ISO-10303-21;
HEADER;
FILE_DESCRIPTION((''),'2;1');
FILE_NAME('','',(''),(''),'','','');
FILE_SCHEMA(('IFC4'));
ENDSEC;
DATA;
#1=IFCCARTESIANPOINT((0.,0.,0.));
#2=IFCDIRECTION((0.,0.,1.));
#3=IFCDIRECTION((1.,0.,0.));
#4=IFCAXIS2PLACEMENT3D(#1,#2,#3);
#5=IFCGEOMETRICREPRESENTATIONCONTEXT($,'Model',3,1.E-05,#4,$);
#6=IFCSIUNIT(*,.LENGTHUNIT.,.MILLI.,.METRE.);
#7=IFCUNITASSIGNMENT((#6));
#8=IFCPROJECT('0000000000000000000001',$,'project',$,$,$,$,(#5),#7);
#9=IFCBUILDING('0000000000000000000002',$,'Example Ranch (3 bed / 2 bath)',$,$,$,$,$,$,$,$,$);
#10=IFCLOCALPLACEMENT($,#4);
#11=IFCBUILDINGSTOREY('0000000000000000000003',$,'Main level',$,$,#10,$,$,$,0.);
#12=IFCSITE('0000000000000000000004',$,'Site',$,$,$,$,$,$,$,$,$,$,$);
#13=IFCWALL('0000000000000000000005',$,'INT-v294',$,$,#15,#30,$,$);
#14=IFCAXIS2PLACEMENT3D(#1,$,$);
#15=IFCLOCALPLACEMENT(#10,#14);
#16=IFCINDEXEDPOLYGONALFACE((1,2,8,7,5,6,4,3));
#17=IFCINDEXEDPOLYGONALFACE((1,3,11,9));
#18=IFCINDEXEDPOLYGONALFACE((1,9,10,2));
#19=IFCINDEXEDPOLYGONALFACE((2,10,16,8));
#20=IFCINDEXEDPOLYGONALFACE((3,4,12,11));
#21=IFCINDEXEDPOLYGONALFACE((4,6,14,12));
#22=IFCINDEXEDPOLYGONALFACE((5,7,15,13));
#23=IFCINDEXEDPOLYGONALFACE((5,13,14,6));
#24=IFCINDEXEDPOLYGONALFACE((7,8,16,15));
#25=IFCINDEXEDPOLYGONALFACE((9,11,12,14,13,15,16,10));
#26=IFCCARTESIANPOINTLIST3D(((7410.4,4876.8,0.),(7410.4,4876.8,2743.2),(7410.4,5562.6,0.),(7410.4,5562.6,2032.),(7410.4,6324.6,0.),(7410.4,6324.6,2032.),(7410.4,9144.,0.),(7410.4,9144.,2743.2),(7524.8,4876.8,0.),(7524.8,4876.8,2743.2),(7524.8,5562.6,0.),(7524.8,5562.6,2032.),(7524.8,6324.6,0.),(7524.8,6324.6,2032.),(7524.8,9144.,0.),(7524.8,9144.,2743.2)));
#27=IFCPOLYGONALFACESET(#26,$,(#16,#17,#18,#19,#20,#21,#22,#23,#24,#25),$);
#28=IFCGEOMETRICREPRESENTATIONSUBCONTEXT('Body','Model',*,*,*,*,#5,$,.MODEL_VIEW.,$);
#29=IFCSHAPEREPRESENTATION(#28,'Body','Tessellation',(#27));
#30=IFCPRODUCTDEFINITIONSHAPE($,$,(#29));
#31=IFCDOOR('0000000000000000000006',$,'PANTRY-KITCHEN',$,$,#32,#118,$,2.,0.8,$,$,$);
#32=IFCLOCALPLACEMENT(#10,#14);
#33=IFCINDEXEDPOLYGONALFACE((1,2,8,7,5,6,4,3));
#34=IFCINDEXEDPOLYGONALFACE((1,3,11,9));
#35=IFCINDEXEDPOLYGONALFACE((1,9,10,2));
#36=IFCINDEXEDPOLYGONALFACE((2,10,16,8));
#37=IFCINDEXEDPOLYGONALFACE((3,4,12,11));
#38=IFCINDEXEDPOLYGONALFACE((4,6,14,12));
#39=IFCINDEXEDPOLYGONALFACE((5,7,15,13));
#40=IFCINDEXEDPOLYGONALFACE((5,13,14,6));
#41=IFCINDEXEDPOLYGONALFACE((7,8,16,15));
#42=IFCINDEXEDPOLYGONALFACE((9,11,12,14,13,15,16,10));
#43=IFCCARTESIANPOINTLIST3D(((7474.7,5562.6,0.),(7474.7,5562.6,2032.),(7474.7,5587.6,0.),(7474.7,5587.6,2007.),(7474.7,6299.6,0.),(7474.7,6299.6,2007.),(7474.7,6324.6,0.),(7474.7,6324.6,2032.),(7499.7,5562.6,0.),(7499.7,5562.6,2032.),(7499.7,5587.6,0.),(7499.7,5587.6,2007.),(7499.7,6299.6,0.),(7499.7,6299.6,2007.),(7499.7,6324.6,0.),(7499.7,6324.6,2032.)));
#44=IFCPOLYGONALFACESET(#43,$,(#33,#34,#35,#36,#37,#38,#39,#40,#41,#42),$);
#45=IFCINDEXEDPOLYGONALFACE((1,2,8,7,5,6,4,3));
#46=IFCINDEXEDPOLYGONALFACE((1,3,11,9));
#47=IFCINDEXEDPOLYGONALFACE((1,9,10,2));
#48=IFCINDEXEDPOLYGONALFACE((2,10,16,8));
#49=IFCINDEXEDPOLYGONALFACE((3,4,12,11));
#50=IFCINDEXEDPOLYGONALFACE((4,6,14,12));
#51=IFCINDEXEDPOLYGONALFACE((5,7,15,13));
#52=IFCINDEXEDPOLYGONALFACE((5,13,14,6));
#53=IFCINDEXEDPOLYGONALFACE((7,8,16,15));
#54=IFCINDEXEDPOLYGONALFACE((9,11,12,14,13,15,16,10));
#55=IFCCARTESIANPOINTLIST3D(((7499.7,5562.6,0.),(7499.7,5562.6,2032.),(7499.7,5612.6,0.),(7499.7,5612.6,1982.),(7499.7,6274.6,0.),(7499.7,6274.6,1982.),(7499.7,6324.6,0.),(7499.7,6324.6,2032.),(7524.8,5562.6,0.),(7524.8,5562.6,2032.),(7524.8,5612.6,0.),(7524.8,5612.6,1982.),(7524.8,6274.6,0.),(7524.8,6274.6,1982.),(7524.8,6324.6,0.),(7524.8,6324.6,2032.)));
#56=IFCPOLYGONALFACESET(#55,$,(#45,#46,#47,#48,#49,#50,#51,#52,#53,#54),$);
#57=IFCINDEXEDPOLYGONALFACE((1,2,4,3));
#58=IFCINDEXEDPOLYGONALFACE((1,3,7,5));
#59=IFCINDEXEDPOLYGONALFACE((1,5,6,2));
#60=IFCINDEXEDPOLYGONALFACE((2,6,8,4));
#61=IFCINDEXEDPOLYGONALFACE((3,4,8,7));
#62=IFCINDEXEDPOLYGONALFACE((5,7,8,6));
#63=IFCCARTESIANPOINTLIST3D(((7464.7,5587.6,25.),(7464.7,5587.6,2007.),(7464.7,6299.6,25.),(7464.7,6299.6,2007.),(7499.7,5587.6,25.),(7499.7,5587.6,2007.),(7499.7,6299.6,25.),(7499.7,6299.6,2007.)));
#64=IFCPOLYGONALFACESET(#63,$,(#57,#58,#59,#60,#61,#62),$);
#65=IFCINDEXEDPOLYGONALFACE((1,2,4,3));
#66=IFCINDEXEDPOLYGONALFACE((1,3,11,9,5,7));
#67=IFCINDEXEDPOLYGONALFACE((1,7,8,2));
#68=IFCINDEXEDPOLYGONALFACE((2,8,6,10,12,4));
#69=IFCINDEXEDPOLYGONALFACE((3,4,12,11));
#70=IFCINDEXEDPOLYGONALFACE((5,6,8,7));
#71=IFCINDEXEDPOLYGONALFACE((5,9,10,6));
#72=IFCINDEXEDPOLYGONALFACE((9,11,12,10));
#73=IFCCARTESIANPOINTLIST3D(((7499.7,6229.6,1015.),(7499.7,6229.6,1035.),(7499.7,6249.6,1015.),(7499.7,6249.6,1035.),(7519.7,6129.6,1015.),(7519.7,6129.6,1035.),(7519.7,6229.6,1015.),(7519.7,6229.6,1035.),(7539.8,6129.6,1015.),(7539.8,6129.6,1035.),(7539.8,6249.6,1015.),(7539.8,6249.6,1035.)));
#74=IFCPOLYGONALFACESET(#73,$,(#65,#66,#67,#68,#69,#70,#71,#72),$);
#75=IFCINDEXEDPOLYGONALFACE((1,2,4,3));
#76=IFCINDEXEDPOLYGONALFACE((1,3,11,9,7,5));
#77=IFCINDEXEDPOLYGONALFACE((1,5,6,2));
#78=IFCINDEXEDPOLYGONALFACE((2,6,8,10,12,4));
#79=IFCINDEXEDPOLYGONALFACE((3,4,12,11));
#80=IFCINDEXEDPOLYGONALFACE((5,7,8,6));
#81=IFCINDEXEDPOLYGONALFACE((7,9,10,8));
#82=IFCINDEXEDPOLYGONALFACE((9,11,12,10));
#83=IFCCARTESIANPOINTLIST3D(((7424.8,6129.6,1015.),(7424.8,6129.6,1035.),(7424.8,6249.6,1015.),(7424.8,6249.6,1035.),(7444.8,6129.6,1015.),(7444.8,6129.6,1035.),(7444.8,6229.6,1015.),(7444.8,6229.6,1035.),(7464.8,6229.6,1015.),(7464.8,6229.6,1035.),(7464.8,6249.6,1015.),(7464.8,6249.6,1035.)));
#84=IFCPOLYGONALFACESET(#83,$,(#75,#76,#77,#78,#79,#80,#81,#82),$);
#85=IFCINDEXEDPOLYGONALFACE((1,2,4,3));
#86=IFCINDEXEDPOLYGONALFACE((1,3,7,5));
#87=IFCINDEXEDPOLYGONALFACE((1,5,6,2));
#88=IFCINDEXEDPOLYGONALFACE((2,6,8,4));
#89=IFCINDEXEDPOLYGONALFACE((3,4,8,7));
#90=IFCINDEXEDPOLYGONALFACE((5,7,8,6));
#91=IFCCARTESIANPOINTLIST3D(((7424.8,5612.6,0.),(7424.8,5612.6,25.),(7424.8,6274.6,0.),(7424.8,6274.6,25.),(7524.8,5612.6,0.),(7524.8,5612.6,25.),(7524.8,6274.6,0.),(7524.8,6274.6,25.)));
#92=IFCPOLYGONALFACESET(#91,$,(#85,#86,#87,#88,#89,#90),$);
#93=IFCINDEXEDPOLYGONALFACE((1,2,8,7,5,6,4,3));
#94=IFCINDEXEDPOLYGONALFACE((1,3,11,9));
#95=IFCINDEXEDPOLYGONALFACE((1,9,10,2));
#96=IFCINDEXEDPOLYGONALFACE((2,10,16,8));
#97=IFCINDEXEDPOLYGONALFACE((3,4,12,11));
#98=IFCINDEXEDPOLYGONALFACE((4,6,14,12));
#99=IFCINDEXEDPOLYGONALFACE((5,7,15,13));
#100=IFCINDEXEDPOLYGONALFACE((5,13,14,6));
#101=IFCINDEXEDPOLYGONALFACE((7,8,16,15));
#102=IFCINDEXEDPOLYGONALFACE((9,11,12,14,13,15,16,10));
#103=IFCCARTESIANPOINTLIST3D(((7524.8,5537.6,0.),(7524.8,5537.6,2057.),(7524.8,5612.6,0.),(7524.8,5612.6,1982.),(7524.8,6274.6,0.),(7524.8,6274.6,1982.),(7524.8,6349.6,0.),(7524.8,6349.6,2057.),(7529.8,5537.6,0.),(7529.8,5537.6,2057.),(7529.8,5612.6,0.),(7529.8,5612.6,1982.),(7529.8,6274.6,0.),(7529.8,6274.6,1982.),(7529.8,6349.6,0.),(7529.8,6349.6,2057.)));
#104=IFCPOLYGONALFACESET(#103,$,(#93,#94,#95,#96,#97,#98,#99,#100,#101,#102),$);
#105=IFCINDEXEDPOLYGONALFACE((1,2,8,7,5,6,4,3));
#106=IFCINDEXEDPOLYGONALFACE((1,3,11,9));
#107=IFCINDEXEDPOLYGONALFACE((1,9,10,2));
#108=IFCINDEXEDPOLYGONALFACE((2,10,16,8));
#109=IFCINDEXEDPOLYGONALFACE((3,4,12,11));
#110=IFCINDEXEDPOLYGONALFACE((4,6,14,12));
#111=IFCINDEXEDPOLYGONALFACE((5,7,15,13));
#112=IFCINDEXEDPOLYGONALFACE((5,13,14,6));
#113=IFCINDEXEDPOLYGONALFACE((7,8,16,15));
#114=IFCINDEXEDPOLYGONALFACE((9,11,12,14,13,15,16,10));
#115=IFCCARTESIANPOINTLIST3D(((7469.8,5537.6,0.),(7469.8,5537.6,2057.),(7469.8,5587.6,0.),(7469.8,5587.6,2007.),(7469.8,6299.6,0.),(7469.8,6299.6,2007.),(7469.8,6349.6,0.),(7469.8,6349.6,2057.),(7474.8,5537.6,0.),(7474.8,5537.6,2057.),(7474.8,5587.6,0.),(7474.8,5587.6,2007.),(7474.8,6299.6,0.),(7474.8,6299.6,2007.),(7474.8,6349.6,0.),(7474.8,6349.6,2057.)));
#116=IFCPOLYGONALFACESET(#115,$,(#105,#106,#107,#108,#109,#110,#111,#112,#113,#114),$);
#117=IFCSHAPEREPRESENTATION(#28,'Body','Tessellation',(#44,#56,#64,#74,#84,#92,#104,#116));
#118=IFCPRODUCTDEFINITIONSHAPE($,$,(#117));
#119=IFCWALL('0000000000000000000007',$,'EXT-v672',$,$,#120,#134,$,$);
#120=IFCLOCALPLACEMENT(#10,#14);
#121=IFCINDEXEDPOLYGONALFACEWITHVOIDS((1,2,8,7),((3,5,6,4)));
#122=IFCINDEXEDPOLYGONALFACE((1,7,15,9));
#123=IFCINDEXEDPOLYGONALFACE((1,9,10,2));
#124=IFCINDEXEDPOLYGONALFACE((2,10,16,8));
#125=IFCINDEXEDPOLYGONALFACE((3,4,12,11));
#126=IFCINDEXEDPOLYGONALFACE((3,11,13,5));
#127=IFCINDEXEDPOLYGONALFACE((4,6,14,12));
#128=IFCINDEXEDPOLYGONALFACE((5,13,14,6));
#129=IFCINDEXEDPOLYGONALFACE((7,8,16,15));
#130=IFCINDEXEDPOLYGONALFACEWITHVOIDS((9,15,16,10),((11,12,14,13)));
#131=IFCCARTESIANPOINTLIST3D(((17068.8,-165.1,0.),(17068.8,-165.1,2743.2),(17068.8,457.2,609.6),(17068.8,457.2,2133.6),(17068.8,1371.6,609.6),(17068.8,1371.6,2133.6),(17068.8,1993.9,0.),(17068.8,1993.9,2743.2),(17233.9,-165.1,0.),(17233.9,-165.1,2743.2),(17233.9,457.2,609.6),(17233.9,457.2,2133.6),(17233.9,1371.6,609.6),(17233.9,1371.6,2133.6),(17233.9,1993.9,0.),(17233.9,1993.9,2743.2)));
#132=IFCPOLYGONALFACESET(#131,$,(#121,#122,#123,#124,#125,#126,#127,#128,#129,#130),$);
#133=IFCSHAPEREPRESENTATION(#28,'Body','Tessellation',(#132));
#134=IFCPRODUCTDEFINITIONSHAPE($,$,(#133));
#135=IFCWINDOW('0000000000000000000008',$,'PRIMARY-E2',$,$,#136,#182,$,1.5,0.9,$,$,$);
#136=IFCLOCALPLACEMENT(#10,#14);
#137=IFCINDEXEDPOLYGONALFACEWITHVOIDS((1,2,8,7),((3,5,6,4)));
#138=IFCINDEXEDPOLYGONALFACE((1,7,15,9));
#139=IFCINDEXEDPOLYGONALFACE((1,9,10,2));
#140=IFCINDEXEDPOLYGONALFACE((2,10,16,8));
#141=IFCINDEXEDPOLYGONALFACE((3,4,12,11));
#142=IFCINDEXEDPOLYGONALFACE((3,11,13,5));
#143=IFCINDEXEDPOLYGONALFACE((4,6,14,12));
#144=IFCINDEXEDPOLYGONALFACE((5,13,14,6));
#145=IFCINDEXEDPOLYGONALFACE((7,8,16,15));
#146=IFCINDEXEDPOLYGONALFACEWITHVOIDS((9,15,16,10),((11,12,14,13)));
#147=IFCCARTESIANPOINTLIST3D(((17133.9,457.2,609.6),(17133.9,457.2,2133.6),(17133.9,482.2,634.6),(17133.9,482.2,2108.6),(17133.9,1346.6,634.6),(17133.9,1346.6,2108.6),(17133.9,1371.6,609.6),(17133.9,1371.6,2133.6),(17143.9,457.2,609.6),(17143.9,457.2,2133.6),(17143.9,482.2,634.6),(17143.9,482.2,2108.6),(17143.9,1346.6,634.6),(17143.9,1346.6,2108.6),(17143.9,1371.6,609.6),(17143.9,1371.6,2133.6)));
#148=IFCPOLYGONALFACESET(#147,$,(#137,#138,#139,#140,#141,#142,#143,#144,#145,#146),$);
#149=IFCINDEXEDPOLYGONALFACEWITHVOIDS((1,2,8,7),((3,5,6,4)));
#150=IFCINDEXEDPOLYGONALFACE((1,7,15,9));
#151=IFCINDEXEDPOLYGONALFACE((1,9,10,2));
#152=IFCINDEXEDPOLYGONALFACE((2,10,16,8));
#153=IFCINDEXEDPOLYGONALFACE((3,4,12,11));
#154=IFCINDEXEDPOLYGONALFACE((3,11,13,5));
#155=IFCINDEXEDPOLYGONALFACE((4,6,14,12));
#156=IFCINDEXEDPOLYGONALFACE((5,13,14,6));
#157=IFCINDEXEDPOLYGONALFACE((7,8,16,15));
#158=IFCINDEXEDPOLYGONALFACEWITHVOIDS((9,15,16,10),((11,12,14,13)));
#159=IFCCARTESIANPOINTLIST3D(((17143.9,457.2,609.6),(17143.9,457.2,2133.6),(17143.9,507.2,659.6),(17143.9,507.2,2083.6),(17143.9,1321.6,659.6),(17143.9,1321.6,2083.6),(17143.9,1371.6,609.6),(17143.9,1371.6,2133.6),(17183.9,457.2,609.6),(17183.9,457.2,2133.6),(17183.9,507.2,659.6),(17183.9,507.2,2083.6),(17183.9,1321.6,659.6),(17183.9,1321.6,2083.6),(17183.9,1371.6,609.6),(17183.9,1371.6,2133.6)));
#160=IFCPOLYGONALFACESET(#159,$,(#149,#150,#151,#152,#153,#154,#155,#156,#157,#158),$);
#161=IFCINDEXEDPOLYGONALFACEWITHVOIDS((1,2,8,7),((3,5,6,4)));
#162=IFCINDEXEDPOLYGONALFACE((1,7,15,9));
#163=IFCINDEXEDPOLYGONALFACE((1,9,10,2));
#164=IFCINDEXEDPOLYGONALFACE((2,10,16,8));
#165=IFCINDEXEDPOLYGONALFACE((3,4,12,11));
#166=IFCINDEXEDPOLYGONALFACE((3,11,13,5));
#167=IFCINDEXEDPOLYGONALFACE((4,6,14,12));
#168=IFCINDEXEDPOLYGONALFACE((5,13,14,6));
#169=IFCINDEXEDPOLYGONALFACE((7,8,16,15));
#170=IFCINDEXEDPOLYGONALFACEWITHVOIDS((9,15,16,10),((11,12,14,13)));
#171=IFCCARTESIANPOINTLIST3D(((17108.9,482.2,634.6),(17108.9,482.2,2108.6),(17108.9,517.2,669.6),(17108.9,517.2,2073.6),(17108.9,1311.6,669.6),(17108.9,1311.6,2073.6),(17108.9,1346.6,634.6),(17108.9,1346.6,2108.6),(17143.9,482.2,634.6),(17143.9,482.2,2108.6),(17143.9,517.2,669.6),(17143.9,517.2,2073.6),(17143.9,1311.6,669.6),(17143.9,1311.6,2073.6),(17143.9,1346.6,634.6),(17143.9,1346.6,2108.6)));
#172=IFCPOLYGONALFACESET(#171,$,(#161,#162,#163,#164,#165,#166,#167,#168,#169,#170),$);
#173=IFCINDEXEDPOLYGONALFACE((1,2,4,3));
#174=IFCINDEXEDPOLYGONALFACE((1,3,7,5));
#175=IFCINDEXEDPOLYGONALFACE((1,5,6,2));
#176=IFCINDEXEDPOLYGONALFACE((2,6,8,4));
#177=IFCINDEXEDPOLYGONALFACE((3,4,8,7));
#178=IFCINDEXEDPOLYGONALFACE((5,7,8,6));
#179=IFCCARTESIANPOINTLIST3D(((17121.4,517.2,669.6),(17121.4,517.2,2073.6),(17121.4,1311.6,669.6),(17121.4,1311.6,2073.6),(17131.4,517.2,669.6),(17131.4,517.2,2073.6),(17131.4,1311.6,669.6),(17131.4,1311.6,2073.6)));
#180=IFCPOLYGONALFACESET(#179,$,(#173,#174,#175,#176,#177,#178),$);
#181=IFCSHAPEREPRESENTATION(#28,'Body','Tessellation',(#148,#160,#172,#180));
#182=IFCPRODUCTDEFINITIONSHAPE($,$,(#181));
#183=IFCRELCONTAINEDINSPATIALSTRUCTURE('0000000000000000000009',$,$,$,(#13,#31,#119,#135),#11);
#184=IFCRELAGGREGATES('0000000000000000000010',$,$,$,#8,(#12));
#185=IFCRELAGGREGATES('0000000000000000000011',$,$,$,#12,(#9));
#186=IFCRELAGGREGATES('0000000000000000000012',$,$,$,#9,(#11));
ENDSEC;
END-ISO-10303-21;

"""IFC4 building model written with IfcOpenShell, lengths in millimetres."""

from ifc_helpers import new_model, si_unit, frame, origin_with_axes, place, context, subcontext, project, spatial, line, indexed_curve, outline, extrude, element, fill, save


model = new_model("IFC4")

# Units and contexts
model_context = context("Model", 3, precision=1e-05, world=origin_with_axes())
body_context = subcontext(model_context, "Body", "Model", "MODEL_VIEW")
ifc_project = project(units=[si_unit("LENGTHUNIT", "METRE", prefix="MILLI")], contexts=[model_context])

# Site, building, storey
site = spatial("IfcSite", under=ifc_project, Name="Site")
building = spatial("IfcBuilding", under=site, Name="Example Ranch (3 bed / 2 bath)")
storey_placement = place(None, origin_with_axes())
storey = spatial("IfcBuildingStorey", under=building, at=storey_placement, Name="Main level", Elevation=0.0)

# Wall, opening, door
wall_1_placement = place(storey_placement, frame((7524.8, 4876.8, 0.0), z_axis=(0.0, 0.0, 1.0), x_axis=(0.0, 1.0, 0.0)))
wall_1 = element("IfcWall", 1, at=wall_1_placement, inside=storey, Name="INT-v294", context=body_context, shape_type="SweptSolid", body=[
    extrude(outline(indexed_curve([(0.0, 0.0), (0.0, 114.3), (4267.2, 114.3), (4267.2, 0.0), (0.0, 0.0)], self_intersect=False)), origin_with_axes(), (0.0, 0.0, 1.0), 2743.2),
])
opening_1_placement = place(wall_1_placement, frame((685.8, 0.0, 0.0), z_axis=(0.0, 0.0, 1.0), x_axis=(1.0, 0.0, 0.0)))
opening_1 = element("IfcOpeningElement", 2, at=opening_1_placement, cuts=wall_1, context=body_context, shape_type="SweptSolid", body=[
    extrude(outline(indexed_curve([(0.0, 0.0), (0.0, 114.3), (762.0, 114.3), (762.0, 0.0), (0.0, 0.0)], self_intersect=False)), origin_with_axes(), (0.0, 0.0, 1.0), 2032.0),
])
door_1_placement = place(storey_placement, frame((7524.8, 5562.6, 0.0), z_axis=(0.0, 0.0, 1.0), x_axis=(0.0, 1.0, 0.0)))
door_1 = element("IfcDoor", 3, at=door_1_placement, inside=storey, Name="PANTRY-KITCHEN", OverallHeight=2.0, OverallWidth=0.8, context=body_context, shape_type="SweptSolid", body=[
    extrude(outline(indexed_curve([(0.0, 0.0), (0.0, 2032.0), (762.0, 2032.0), (762.0, 0.0), (737.0, 0.0), (737.0, 2007.0), (25.0, 2007.0), (25.0, 0.0)], segments=[line(1, 2, 3, 4, 5, 6, 7, 8, 1)])), frame((0.0, 25.0, 0.0), z_axis=(0.0, -1.0, 0.0), x_axis=(1.0, 0.0, 0.0)), (0.0, 0.0, -1.0), 25.0),
    extrude(outline(indexed_curve([(0.0, 0.0), (0.0, 2032.0), (762.0, 2032.0), (762.0, 0.0), (712.0, 0.0), (712.0, 1982.0), (50.0, 1982.0), (50.0, 0.0)], segments=[line(1, 2, 3, 4, 5, 6, 7, 8, 1)])), frame((0.0, 0.0, 0.0), z_axis=(0.0, -1.0, 0.0), x_axis=(1.0, 0.0, 0.0)), (0.0, 0.0, -1.0), 25.0),
    extrude(outline(indexed_curve([(0.0, 0.0), (712.0, 0.0), (712.0, 35.0), (0.0, 35.0)], segments=[line(1, 2, 3, 4, 1)])), frame((25.0, 25.0, 25.0), z_axis=(0.0, 0.0, 1.0), x_axis=(1.0, 0.0, 0.0)), (0.0, 0.0, 1.0), 1982.0),
    extrude(outline(indexed_curve([(0.0, 0.0), (0.0, -40.0), (-120.0, -40.0), (-120.0, -20.0), (-20.0, -20.0), (-20.0, 0.0)], segments=[line(1, 2, 3, 4, 5, 6, 1)])), frame((687.0, 25.0, 1015.0), z_axis=(0.0, 0.0, 1.0), x_axis=(1.0, 0.0, 0.0)), (0.0, 0.0, 1.0), 20.0),
    extrude(outline(indexed_curve([(0.0, 0.0), (0.0, 40.0), (-120.0, 40.0), (-120.0, 20.0), (-20.0, 20.0), (-20.0, 0.0)], segments=[line(1, 2, 3, 4, 5, 6, 1)])), frame((687.0, 60.0, 1015.0), z_axis=(0.0, 0.0, 1.0), x_axis=(1.0, 0.0, 0.0)), (0.0, 0.0, 1.0), 20.0),
    extrude(outline(indexed_curve([(0.0, 0.0), (662.0, 0.0), (662.0, 100.0), (0.0, 100.0)], segments=[line(1, 2, 3, 4, 1)])), frame((50.0, 0.0, 0.0), z_axis=(0.0, 0.0, 1.0), x_axis=(1.0, 0.0, 0.0)), (0.0, 0.0, 1.0), 25.0),
    extrude(outline(indexed_curve([(0.0, 0.0), (0.0, 2057.0), (812.0, 2057.0), (812.0, 0.0), (737.0, 0.0), (737.0, 1982.0), (75.0, 1982.0), (75.0, 0.0)], segments=[line(1, 2, 3, 4, 5, 6, 7, 8, 1)])), frame((-25.0, -5.0, 0.0), z_axis=(0.0, -1.0, 0.0), x_axis=(1.0, 0.0, 0.0)), (0.0, 0.0, -1.0), 5.0),
    extrude(outline(indexed_curve([(0.0, 0.0), (0.0, 2057.0), (812.0, 2057.0), (812.0, 0.0), (762.0, 0.0), (762.0, 2007.0), (50.0, 2007.0), (50.0, 0.0)], segments=[line(1, 2, 3, 4, 5, 6, 7, 8, 1)])), frame((-25.0, 50.0, 0.0), z_axis=(0.0, -1.0, 0.0), x_axis=(1.0, 0.0, 0.0)), (0.0, 0.0, -1.0), 5.0),
])
fill(opening_1, door_1)

# Wall, opening, window
wall_2_placement = place(storey_placement, frame((17233.9, -165.1, 0.0), z_axis=(0.0, 0.0, 1.0), x_axis=(0.0, 1.0, 0.0)))
wall_2 = element("IfcWall", 4, at=wall_2_placement, inside=storey, Name="EXT-v672", context=body_context, shape_type="SweptSolid", body=[
    extrude(outline(indexed_curve([(0.0, 0.0), (0.0, 165.1), (2159.0, 165.1), (2159.0, 0.0), (0.0, 0.0)], self_intersect=False)), origin_with_axes(), (0.0, 0.0, 1.0), 2743.2),
])
opening_2_placement = place(wall_2_placement, frame((622.3, 0.0, 609.6), z_axis=(0.0, 0.0, 1.0), x_axis=(1.0, 0.0, 0.0)))
opening_2 = element("IfcOpeningElement", 5, at=opening_2_placement, cuts=wall_2, context=body_context, shape_type="SweptSolid", body=[
    extrude(outline(indexed_curve([(0.0, 0.0), (0.0, 165.1), (914.4, 165.1), (914.4, 0.0), (0.0, 0.0)], self_intersect=False)), origin_with_axes(), (0.0, 0.0, 1.0), 1524.0),
])
window_placement = place(storey_placement, frame((17233.9, 457.2, 609.6), z_axis=(0.0, 0.0, 1.0), x_axis=(0.0, 1.0, 0.0)))
window = element("IfcWindow", 6, at=window_placement, inside=storey, Name="PRIMARY-E2", OverallHeight=1.5, OverallWidth=0.9, context=body_context, shape_type="SweptSolid", body=[
    extrude(outline(indexed_curve([(0.0, 0.0), (914.4, 0.0), (914.4, 1524.0), (0.0, 1524.0)], segments=[line(1, 2, 3, 4, 1)]), holes=[indexed_curve([(25.0, 25.0), (889.4, 25.0), (889.4, 1499.0), (25.0, 1499.0)], segments=[line(1, 2, 3, 4, 1)])]), frame((0.0, 90.0, 0.0), z_axis=(0.0, -1.0, 0.0), x_axis=(1.0, 0.0, 0.0)), (0.0, 0.0, -1.0), 10.0),
    extrude(outline(indexed_curve([(0.0, 0.0), (914.4, 0.0), (914.4, 1524.0), (0.0, 1524.0)], segments=[line(1, 2, 3, 4, 1)]), holes=[indexed_curve([(50.0, 50.0), (864.4, 50.0), (864.4, 1474.0), (50.0, 1474.0)], segments=[line(1, 2, 3, 4, 1)])]), frame((0.0, 50.0, 0.0), z_axis=(0.0, -1.0, 0.0), x_axis=(1.0, 0.0, 0.0)), (0.0, 0.0, -1.0), 40.0),
    extrude(outline(indexed_curve([(0.0, 0.0), (864.4, 0.0), (864.4, 1474.0), (0.0, 1474.0)], segments=[line(1, 2, 3, 4, 1)]), holes=[indexed_curve([(35.0, 35.0), (829.4, 35.0), (829.4, 1439.0), (35.0, 1439.0)], segments=[line(1, 2, 3, 4, 1)])]), frame((25.0, 90.0, 25.0), z_axis=(0.0, -1.0, 0.0), x_axis=(1.0, 0.0, 0.0)), (0.0, 0.0, -1.0), 35.0),
    extrude(outline(indexed_curve([(35.0, 35.0), (829.4, 35.0), (829.4, 1439.0), (35.0, 1439.0)], segments=[line(1, 2, 3, 4, 1)])), frame((25.0, 102.5, 25.0), z_axis=(0.0, -1.0, 0.0), x_axis=(1.0, 0.0, 0.0)), (0.0, 0.0, -1.0), 10.0),
])
fill(opening_2, window)

save(model, "model.ifc")
